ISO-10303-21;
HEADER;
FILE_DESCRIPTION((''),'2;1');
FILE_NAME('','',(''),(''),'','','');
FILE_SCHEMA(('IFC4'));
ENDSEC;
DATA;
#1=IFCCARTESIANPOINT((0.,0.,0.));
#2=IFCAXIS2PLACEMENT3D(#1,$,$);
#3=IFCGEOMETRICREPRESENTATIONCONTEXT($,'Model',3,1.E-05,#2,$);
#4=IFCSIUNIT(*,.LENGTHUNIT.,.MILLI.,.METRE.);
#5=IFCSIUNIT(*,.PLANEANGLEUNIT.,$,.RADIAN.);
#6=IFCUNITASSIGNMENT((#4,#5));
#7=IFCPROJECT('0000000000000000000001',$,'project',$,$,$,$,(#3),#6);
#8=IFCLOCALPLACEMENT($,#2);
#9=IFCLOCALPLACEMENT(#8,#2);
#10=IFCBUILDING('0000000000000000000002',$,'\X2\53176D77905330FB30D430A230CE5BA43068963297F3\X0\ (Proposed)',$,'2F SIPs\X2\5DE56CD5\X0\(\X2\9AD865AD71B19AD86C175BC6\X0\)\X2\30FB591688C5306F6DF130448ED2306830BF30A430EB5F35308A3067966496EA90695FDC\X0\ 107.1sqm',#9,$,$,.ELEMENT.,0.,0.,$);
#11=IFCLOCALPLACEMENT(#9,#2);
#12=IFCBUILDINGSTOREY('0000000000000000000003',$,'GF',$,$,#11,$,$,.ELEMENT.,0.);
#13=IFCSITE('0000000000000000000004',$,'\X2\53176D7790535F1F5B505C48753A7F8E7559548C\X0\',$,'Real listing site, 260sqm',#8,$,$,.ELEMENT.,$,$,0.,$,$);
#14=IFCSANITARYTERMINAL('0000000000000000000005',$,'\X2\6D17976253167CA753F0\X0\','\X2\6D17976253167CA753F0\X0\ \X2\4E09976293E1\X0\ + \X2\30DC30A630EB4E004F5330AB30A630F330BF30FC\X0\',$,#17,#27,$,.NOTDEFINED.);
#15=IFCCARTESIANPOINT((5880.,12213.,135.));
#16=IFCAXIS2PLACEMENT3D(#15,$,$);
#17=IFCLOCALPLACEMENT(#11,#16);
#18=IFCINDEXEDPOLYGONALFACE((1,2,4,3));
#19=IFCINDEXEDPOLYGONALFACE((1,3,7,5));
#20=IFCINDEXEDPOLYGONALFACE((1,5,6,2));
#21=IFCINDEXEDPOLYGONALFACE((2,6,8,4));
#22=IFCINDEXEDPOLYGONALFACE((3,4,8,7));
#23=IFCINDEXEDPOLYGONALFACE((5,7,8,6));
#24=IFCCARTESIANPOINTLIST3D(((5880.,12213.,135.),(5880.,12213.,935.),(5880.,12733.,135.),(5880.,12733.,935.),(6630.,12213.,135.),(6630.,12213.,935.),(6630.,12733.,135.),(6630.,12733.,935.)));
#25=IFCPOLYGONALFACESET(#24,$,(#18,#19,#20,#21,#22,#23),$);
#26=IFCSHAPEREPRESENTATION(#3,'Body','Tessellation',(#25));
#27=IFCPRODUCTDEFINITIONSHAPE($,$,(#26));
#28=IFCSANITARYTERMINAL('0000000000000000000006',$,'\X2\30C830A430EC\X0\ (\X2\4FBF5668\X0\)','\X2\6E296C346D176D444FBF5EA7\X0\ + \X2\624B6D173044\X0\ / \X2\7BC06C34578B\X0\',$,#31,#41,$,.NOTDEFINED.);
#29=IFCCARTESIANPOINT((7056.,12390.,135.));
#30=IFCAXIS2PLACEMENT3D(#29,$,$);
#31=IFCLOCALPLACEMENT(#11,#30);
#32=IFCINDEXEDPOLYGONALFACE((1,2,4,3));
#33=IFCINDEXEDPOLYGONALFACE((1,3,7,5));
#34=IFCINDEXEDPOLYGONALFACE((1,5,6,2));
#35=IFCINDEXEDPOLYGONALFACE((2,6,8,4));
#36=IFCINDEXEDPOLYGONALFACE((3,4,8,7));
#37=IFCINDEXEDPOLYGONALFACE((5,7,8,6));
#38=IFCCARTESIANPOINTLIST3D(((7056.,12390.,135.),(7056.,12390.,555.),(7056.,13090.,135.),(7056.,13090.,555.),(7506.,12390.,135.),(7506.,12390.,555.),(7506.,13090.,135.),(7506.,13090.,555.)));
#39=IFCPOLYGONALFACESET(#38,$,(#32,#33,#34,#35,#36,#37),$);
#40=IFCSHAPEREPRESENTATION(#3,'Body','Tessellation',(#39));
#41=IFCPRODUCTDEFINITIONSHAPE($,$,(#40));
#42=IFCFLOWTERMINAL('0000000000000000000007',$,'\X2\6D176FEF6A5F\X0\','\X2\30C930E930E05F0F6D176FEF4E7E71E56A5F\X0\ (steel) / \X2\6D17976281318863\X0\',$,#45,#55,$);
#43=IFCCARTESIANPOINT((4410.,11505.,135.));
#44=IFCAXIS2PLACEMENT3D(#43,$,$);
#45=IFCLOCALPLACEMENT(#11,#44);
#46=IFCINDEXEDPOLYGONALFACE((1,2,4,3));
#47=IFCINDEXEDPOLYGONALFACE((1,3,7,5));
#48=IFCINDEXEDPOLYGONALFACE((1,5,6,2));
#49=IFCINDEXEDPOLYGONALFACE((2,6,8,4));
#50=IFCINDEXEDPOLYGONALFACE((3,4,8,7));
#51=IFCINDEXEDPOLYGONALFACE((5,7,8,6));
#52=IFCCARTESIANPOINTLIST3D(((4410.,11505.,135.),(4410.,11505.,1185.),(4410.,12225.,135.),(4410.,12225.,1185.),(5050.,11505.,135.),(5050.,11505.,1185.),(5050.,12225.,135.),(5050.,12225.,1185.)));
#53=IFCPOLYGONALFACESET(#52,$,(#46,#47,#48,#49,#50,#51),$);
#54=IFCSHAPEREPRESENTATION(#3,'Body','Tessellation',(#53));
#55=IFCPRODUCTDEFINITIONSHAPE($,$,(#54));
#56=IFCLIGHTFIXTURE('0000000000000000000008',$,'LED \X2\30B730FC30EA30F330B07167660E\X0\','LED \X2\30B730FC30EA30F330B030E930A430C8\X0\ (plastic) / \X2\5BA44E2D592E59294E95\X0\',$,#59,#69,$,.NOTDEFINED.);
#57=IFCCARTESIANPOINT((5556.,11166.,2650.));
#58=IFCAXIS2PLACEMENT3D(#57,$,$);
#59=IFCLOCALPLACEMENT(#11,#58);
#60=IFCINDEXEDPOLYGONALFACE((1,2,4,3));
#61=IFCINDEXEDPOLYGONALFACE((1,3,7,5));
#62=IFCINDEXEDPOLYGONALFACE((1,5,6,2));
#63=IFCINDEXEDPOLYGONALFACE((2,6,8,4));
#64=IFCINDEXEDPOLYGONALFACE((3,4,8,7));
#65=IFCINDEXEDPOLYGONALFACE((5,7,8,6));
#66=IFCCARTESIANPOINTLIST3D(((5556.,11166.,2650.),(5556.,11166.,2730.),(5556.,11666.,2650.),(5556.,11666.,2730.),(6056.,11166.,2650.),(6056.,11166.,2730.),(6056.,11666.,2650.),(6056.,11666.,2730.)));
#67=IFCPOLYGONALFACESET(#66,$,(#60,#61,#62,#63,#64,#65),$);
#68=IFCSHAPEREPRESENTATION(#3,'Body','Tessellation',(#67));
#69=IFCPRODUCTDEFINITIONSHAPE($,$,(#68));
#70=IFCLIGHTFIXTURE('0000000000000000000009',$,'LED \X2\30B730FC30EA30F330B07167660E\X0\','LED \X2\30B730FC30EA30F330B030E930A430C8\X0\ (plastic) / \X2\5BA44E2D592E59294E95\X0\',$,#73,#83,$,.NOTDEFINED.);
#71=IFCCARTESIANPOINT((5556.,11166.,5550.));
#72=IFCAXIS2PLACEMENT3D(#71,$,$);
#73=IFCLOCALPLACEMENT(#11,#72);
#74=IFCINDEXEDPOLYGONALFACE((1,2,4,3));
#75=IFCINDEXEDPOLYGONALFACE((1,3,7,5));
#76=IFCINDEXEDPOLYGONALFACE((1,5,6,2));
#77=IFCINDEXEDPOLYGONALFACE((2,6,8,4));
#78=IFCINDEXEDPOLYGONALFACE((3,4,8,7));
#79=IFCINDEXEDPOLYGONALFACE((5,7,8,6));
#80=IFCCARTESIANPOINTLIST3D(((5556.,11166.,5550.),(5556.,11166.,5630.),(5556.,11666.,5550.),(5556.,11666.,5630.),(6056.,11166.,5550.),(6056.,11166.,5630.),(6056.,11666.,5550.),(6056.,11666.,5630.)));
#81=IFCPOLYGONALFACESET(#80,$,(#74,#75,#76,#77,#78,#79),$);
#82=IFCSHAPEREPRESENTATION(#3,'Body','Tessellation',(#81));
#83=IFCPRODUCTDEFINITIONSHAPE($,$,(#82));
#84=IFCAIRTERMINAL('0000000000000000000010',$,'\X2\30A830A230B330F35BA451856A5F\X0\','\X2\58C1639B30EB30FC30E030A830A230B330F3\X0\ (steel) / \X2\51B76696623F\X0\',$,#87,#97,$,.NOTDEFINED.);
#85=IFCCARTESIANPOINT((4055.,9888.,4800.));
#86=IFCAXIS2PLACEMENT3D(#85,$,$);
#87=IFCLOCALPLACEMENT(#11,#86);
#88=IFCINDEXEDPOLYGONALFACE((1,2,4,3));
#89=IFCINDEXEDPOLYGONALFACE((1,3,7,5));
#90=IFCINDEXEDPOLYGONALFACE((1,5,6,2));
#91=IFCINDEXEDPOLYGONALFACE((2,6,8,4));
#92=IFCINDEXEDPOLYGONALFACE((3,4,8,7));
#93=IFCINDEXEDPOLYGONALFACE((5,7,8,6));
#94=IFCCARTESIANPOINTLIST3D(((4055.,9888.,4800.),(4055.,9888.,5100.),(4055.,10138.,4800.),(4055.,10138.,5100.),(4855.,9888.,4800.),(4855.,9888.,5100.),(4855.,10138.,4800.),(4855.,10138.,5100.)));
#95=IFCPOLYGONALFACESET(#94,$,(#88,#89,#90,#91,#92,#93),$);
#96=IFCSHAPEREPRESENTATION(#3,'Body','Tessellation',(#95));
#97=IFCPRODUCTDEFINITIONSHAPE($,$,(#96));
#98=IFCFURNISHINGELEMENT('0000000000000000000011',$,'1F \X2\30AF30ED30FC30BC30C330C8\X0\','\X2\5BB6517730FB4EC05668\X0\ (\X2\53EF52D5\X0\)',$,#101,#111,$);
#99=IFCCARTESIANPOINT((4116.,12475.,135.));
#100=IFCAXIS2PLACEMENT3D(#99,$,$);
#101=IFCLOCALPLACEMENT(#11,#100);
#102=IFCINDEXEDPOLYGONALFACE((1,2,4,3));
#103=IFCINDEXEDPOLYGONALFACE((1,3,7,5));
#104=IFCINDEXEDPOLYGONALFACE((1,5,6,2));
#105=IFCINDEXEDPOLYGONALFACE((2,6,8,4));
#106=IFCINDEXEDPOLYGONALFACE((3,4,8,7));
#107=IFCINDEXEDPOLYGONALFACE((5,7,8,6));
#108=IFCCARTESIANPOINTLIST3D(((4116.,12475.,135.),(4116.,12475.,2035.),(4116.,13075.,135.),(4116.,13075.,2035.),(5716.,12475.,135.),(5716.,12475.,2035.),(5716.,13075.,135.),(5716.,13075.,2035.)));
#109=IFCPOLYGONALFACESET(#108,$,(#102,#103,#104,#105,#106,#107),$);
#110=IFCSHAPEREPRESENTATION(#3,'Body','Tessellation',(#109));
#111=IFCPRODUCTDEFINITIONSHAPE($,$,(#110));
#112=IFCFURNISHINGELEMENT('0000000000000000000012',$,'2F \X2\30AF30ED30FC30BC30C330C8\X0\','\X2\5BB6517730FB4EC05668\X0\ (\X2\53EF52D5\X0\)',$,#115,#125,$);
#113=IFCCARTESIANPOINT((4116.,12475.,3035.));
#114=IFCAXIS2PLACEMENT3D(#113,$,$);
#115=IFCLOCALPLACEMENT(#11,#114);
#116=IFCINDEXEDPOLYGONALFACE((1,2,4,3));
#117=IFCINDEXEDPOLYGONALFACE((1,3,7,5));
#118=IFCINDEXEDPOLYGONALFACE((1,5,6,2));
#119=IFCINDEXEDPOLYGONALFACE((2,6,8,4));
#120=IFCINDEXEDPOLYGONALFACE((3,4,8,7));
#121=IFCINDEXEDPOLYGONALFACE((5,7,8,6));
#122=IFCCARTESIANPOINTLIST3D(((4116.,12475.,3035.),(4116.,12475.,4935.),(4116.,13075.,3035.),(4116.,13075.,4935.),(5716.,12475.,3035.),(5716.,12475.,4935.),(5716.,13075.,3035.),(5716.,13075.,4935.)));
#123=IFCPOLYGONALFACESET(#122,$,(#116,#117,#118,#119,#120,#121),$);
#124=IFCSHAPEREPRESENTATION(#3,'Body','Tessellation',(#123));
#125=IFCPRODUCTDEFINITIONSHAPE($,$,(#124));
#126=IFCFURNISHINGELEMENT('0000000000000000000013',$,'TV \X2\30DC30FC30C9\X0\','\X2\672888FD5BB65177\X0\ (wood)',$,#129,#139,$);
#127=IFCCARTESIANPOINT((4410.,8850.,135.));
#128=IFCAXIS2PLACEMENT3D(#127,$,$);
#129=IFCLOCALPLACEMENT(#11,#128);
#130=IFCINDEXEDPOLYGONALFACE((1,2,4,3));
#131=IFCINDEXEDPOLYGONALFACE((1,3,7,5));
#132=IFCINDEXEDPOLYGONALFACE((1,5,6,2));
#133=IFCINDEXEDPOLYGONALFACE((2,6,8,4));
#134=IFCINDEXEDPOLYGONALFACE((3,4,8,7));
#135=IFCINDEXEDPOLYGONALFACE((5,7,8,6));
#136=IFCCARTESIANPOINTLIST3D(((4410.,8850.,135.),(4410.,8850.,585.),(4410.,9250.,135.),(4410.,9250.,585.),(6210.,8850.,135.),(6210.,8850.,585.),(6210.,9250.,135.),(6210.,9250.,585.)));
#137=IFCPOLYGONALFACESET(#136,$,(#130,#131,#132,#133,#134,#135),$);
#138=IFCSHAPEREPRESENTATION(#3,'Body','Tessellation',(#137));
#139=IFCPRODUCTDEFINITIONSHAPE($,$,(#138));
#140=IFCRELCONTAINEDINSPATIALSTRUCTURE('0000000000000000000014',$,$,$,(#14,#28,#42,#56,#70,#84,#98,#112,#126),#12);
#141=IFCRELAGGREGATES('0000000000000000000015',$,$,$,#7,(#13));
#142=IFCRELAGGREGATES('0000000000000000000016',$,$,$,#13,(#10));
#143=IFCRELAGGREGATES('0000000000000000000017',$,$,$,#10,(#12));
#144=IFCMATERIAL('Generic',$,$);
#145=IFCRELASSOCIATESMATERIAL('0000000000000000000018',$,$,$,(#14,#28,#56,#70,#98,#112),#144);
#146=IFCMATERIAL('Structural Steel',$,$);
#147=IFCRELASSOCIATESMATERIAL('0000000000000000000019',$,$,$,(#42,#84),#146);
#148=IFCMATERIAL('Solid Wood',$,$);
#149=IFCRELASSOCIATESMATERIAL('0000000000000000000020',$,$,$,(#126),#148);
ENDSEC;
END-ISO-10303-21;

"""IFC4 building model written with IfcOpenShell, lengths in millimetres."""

from ifc_helpers import new_model, si_unit, frame, frame_2d, origin, place, context, project, spatial, rectangle, extrude, material, element, save


model = new_model("IFC4")

# Units and contexts
model_context = context("Model", 3, precision=1e-05, world=origin())
ifc_project = project(units=[si_unit("LENGTHUNIT", "METRE", prefix="MILLI"), si_unit("PLANEANGLEUNIT", "RADIAN")], contexts=[model_context])

# Site, building, storey
site_placement = place(None, origin())
site = spatial("IfcSite", under=ifc_project, at=site_placement, Name="北海道弟子屈町美留和", ObjectType="Real listing site, 260sqm", CompositionType="ELEMENT", RefElevation=0.0)
building_placement = place(site_placement, origin())
building = spatial("IfcBuilding", under=site, at=building_placement, Name="北海道・ピアノ室と防音 (Proposed)", ObjectType="2F SIPs工法(高断熱高気密)・外装は深い軒とタイル張りで除雪適応 107.1sqm", CompositionType="ELEMENT", ElevationOfRefHeight=0.0, ElevationOfTerrain=0.0)
storey_placement = place(building_placement, origin())
storey = spatial("IfcBuildingStorey", under=building, at=storey_placement, Name="GF", CompositionType="ELEMENT", Elevation=0.0)

# Shared definitions
ifc_material_1 = material(Name="Solid Wood")

# Sanitary terminals
ifc_material_2 = material(Name="Generic")
sanitary_terminal_1_placement = place(storey_placement, frame((5880.0, 12213.0, 135.0)))
element("IfcSanitaryTerminal", 1, at=sanitary_terminal_1_placement, inside=storey, material=ifc_material_2, Name="洗面化粧台", Description="洗面化粧台 三面鏡 + ボウル一体カウンター", PredefinedType="NOTDEFINED", context=model_context, shape_type="SweptSolid", body=[
    extrude(rectangle(XDim=750.0, YDim=520.0, at=frame_2d((375.0, 260.0))), frame((5880.0, 12213.0, 135.0)), (0.0, 0.0, 1.0), 800.0),
])
sanitary_terminal_2_placement = place(storey_placement, frame((7056.0, 12390.0, 135.0)))
element("IfcSanitaryTerminal", 2, at=sanitary_terminal_2_placement, inside=storey, material=ifc_material_2, Name="トイレ (便器)", Description="温水洗浄便座 + 手洗い / 節水型", PredefinedType="NOTDEFINED", context=model_context, shape_type="SweptSolid", body=[
    extrude(rectangle(XDim=450.0, YDim=700.0, at=frame_2d((225.0, 350.0))), frame((7056.0, 12390.0, 135.0)), (0.0, 0.0, 1.0), 420.0),
])

# Flow terminal
ifc_material_3 = material(Name="Structural Steel")
flow_terminal_placement = place(storey_placement, frame((4410.0, 11505.0, 135.0)))
element("IfcFlowTerminal", 3, at=flow_terminal_placement, inside=storey, material=ifc_material_3, Name="洗濯機", Description="ドラム式洗濯乾燥機 (steel) / 洗面脱衣", context=model_context, shape_type="SweptSolid", body=[
    extrude(rectangle(XDim=640.0, YDim=720.0, at=frame_2d((320.0, 360.0))), frame((4410.0, 11505.0, 135.0)), (0.0, 0.0, 1.0), 1050.0),
])

# Light fixtures
light_fixture_1_placement = place(storey_placement, frame((5556.0, 11166.0, 2650.0)))
element("IfcLightFixture", 4, at=light_fixture_1_placement, inside=storey, material=ifc_material_2, Name="LED シーリング照明", Description="LED シーリングライト (plastic) / 室中央天井", PredefinedType="NOTDEFINED", context=model_context, shape_type="SweptSolid", body=[
    extrude(rectangle(XDim=500.0, YDim=500.0, at=frame_2d((250.0, 250.0))), frame((5556.0, 11166.0, 2650.0)), (0.0, 0.0, 1.0), 80.0),
])
light_fixture_2_placement = place(storey_placement, frame((5556.0, 11166.0, 5550.0)))
element("IfcLightFixture", 5, at=light_fixture_2_placement, inside=storey, material=ifc_material_2, Name="LED シーリング照明", Description="LED シーリングライト (plastic) / 室中央天井", PredefinedType="NOTDEFINED", context=model_context, shape_type="SweptSolid", body=[
    extrude(rectangle(XDim=500.0, YDim=500.0, at=frame_2d((250.0, 250.0))), frame((5556.0, 11166.0, 5550.0)), (0.0, 0.0, 1.0), 80.0),
])

# Air terminal
air_terminal_placement = place(storey_placement, frame((4055.0, 9888.0, 4800.0)))
element("IfcAirTerminal", 6, at=air_terminal_placement, inside=storey, material=ifc_material_3, Name="エアコン室内機", Description="壁掛ルームエアコン (steel) / 冷暖房", PredefinedType="NOTDEFINED", context=model_context, shape_type="SweptSolid", body=[
    extrude(rectangle(XDim=800.0, YDim=250.0, at=frame_2d((400.0, 125.0))), frame((4055.0, 9888.0, 4800.0)), (0.0, 0.0, 1.0), 300.0),
])

# Furnishing elements
furnishing_1_placement = place(storey_placement, frame((4116.0, 12475.0, 135.0)))
element("IfcFurnishingElement", 7, at=furnishing_1_placement, inside=storey, material=ifc_material_2, Name="1F クローゼット", Description="家具・什器 (可動)", context=model_context, shape_type="SweptSolid", body=[
    extrude(rectangle(XDim=1600.0, YDim=600.0, at=frame_2d((800.0, 300.0))), frame((4116.0, 12475.0, 135.0)), (0.0, 0.0, 1.0), 1900.0),
])
furnishing_2_placement = place(storey_placement, frame((4116.0, 12475.0, 3035.0)))
element("IfcFurnishingElement", 8, at=furnishing_2_placement, inside=storey, material=ifc_material_2, Name="2F クローゼット", Description="家具・什器 (可動)", context=model_context, shape_type="SweptSolid", body=[
    extrude(rectangle(XDim=1600.0, YDim=600.0, at=frame_2d((800.0, 300.0))), frame((4116.0, 12475.0, 3035.0)), (0.0, 0.0, 1.0), 1900.0),
])
furnishing_3_placement = place(storey_placement, frame((4410.0, 8850.0, 135.0)))
element("IfcFurnishingElement", 9, at=furnishing_3_placement, inside=storey, material=ifc_material_1, Name="TV ボード", Description="木製家具 (wood)", context=model_context, shape_type="SweptSolid", body=[
    extrude(rectangle(XDim=1800.0, YDim=400.0, at=frame_2d((900.0, 200.0))), frame((4410.0, 8850.0, 135.0)), (0.0, 0.0, 1.0), 450.0),
])

save(model, "model.ifc")
